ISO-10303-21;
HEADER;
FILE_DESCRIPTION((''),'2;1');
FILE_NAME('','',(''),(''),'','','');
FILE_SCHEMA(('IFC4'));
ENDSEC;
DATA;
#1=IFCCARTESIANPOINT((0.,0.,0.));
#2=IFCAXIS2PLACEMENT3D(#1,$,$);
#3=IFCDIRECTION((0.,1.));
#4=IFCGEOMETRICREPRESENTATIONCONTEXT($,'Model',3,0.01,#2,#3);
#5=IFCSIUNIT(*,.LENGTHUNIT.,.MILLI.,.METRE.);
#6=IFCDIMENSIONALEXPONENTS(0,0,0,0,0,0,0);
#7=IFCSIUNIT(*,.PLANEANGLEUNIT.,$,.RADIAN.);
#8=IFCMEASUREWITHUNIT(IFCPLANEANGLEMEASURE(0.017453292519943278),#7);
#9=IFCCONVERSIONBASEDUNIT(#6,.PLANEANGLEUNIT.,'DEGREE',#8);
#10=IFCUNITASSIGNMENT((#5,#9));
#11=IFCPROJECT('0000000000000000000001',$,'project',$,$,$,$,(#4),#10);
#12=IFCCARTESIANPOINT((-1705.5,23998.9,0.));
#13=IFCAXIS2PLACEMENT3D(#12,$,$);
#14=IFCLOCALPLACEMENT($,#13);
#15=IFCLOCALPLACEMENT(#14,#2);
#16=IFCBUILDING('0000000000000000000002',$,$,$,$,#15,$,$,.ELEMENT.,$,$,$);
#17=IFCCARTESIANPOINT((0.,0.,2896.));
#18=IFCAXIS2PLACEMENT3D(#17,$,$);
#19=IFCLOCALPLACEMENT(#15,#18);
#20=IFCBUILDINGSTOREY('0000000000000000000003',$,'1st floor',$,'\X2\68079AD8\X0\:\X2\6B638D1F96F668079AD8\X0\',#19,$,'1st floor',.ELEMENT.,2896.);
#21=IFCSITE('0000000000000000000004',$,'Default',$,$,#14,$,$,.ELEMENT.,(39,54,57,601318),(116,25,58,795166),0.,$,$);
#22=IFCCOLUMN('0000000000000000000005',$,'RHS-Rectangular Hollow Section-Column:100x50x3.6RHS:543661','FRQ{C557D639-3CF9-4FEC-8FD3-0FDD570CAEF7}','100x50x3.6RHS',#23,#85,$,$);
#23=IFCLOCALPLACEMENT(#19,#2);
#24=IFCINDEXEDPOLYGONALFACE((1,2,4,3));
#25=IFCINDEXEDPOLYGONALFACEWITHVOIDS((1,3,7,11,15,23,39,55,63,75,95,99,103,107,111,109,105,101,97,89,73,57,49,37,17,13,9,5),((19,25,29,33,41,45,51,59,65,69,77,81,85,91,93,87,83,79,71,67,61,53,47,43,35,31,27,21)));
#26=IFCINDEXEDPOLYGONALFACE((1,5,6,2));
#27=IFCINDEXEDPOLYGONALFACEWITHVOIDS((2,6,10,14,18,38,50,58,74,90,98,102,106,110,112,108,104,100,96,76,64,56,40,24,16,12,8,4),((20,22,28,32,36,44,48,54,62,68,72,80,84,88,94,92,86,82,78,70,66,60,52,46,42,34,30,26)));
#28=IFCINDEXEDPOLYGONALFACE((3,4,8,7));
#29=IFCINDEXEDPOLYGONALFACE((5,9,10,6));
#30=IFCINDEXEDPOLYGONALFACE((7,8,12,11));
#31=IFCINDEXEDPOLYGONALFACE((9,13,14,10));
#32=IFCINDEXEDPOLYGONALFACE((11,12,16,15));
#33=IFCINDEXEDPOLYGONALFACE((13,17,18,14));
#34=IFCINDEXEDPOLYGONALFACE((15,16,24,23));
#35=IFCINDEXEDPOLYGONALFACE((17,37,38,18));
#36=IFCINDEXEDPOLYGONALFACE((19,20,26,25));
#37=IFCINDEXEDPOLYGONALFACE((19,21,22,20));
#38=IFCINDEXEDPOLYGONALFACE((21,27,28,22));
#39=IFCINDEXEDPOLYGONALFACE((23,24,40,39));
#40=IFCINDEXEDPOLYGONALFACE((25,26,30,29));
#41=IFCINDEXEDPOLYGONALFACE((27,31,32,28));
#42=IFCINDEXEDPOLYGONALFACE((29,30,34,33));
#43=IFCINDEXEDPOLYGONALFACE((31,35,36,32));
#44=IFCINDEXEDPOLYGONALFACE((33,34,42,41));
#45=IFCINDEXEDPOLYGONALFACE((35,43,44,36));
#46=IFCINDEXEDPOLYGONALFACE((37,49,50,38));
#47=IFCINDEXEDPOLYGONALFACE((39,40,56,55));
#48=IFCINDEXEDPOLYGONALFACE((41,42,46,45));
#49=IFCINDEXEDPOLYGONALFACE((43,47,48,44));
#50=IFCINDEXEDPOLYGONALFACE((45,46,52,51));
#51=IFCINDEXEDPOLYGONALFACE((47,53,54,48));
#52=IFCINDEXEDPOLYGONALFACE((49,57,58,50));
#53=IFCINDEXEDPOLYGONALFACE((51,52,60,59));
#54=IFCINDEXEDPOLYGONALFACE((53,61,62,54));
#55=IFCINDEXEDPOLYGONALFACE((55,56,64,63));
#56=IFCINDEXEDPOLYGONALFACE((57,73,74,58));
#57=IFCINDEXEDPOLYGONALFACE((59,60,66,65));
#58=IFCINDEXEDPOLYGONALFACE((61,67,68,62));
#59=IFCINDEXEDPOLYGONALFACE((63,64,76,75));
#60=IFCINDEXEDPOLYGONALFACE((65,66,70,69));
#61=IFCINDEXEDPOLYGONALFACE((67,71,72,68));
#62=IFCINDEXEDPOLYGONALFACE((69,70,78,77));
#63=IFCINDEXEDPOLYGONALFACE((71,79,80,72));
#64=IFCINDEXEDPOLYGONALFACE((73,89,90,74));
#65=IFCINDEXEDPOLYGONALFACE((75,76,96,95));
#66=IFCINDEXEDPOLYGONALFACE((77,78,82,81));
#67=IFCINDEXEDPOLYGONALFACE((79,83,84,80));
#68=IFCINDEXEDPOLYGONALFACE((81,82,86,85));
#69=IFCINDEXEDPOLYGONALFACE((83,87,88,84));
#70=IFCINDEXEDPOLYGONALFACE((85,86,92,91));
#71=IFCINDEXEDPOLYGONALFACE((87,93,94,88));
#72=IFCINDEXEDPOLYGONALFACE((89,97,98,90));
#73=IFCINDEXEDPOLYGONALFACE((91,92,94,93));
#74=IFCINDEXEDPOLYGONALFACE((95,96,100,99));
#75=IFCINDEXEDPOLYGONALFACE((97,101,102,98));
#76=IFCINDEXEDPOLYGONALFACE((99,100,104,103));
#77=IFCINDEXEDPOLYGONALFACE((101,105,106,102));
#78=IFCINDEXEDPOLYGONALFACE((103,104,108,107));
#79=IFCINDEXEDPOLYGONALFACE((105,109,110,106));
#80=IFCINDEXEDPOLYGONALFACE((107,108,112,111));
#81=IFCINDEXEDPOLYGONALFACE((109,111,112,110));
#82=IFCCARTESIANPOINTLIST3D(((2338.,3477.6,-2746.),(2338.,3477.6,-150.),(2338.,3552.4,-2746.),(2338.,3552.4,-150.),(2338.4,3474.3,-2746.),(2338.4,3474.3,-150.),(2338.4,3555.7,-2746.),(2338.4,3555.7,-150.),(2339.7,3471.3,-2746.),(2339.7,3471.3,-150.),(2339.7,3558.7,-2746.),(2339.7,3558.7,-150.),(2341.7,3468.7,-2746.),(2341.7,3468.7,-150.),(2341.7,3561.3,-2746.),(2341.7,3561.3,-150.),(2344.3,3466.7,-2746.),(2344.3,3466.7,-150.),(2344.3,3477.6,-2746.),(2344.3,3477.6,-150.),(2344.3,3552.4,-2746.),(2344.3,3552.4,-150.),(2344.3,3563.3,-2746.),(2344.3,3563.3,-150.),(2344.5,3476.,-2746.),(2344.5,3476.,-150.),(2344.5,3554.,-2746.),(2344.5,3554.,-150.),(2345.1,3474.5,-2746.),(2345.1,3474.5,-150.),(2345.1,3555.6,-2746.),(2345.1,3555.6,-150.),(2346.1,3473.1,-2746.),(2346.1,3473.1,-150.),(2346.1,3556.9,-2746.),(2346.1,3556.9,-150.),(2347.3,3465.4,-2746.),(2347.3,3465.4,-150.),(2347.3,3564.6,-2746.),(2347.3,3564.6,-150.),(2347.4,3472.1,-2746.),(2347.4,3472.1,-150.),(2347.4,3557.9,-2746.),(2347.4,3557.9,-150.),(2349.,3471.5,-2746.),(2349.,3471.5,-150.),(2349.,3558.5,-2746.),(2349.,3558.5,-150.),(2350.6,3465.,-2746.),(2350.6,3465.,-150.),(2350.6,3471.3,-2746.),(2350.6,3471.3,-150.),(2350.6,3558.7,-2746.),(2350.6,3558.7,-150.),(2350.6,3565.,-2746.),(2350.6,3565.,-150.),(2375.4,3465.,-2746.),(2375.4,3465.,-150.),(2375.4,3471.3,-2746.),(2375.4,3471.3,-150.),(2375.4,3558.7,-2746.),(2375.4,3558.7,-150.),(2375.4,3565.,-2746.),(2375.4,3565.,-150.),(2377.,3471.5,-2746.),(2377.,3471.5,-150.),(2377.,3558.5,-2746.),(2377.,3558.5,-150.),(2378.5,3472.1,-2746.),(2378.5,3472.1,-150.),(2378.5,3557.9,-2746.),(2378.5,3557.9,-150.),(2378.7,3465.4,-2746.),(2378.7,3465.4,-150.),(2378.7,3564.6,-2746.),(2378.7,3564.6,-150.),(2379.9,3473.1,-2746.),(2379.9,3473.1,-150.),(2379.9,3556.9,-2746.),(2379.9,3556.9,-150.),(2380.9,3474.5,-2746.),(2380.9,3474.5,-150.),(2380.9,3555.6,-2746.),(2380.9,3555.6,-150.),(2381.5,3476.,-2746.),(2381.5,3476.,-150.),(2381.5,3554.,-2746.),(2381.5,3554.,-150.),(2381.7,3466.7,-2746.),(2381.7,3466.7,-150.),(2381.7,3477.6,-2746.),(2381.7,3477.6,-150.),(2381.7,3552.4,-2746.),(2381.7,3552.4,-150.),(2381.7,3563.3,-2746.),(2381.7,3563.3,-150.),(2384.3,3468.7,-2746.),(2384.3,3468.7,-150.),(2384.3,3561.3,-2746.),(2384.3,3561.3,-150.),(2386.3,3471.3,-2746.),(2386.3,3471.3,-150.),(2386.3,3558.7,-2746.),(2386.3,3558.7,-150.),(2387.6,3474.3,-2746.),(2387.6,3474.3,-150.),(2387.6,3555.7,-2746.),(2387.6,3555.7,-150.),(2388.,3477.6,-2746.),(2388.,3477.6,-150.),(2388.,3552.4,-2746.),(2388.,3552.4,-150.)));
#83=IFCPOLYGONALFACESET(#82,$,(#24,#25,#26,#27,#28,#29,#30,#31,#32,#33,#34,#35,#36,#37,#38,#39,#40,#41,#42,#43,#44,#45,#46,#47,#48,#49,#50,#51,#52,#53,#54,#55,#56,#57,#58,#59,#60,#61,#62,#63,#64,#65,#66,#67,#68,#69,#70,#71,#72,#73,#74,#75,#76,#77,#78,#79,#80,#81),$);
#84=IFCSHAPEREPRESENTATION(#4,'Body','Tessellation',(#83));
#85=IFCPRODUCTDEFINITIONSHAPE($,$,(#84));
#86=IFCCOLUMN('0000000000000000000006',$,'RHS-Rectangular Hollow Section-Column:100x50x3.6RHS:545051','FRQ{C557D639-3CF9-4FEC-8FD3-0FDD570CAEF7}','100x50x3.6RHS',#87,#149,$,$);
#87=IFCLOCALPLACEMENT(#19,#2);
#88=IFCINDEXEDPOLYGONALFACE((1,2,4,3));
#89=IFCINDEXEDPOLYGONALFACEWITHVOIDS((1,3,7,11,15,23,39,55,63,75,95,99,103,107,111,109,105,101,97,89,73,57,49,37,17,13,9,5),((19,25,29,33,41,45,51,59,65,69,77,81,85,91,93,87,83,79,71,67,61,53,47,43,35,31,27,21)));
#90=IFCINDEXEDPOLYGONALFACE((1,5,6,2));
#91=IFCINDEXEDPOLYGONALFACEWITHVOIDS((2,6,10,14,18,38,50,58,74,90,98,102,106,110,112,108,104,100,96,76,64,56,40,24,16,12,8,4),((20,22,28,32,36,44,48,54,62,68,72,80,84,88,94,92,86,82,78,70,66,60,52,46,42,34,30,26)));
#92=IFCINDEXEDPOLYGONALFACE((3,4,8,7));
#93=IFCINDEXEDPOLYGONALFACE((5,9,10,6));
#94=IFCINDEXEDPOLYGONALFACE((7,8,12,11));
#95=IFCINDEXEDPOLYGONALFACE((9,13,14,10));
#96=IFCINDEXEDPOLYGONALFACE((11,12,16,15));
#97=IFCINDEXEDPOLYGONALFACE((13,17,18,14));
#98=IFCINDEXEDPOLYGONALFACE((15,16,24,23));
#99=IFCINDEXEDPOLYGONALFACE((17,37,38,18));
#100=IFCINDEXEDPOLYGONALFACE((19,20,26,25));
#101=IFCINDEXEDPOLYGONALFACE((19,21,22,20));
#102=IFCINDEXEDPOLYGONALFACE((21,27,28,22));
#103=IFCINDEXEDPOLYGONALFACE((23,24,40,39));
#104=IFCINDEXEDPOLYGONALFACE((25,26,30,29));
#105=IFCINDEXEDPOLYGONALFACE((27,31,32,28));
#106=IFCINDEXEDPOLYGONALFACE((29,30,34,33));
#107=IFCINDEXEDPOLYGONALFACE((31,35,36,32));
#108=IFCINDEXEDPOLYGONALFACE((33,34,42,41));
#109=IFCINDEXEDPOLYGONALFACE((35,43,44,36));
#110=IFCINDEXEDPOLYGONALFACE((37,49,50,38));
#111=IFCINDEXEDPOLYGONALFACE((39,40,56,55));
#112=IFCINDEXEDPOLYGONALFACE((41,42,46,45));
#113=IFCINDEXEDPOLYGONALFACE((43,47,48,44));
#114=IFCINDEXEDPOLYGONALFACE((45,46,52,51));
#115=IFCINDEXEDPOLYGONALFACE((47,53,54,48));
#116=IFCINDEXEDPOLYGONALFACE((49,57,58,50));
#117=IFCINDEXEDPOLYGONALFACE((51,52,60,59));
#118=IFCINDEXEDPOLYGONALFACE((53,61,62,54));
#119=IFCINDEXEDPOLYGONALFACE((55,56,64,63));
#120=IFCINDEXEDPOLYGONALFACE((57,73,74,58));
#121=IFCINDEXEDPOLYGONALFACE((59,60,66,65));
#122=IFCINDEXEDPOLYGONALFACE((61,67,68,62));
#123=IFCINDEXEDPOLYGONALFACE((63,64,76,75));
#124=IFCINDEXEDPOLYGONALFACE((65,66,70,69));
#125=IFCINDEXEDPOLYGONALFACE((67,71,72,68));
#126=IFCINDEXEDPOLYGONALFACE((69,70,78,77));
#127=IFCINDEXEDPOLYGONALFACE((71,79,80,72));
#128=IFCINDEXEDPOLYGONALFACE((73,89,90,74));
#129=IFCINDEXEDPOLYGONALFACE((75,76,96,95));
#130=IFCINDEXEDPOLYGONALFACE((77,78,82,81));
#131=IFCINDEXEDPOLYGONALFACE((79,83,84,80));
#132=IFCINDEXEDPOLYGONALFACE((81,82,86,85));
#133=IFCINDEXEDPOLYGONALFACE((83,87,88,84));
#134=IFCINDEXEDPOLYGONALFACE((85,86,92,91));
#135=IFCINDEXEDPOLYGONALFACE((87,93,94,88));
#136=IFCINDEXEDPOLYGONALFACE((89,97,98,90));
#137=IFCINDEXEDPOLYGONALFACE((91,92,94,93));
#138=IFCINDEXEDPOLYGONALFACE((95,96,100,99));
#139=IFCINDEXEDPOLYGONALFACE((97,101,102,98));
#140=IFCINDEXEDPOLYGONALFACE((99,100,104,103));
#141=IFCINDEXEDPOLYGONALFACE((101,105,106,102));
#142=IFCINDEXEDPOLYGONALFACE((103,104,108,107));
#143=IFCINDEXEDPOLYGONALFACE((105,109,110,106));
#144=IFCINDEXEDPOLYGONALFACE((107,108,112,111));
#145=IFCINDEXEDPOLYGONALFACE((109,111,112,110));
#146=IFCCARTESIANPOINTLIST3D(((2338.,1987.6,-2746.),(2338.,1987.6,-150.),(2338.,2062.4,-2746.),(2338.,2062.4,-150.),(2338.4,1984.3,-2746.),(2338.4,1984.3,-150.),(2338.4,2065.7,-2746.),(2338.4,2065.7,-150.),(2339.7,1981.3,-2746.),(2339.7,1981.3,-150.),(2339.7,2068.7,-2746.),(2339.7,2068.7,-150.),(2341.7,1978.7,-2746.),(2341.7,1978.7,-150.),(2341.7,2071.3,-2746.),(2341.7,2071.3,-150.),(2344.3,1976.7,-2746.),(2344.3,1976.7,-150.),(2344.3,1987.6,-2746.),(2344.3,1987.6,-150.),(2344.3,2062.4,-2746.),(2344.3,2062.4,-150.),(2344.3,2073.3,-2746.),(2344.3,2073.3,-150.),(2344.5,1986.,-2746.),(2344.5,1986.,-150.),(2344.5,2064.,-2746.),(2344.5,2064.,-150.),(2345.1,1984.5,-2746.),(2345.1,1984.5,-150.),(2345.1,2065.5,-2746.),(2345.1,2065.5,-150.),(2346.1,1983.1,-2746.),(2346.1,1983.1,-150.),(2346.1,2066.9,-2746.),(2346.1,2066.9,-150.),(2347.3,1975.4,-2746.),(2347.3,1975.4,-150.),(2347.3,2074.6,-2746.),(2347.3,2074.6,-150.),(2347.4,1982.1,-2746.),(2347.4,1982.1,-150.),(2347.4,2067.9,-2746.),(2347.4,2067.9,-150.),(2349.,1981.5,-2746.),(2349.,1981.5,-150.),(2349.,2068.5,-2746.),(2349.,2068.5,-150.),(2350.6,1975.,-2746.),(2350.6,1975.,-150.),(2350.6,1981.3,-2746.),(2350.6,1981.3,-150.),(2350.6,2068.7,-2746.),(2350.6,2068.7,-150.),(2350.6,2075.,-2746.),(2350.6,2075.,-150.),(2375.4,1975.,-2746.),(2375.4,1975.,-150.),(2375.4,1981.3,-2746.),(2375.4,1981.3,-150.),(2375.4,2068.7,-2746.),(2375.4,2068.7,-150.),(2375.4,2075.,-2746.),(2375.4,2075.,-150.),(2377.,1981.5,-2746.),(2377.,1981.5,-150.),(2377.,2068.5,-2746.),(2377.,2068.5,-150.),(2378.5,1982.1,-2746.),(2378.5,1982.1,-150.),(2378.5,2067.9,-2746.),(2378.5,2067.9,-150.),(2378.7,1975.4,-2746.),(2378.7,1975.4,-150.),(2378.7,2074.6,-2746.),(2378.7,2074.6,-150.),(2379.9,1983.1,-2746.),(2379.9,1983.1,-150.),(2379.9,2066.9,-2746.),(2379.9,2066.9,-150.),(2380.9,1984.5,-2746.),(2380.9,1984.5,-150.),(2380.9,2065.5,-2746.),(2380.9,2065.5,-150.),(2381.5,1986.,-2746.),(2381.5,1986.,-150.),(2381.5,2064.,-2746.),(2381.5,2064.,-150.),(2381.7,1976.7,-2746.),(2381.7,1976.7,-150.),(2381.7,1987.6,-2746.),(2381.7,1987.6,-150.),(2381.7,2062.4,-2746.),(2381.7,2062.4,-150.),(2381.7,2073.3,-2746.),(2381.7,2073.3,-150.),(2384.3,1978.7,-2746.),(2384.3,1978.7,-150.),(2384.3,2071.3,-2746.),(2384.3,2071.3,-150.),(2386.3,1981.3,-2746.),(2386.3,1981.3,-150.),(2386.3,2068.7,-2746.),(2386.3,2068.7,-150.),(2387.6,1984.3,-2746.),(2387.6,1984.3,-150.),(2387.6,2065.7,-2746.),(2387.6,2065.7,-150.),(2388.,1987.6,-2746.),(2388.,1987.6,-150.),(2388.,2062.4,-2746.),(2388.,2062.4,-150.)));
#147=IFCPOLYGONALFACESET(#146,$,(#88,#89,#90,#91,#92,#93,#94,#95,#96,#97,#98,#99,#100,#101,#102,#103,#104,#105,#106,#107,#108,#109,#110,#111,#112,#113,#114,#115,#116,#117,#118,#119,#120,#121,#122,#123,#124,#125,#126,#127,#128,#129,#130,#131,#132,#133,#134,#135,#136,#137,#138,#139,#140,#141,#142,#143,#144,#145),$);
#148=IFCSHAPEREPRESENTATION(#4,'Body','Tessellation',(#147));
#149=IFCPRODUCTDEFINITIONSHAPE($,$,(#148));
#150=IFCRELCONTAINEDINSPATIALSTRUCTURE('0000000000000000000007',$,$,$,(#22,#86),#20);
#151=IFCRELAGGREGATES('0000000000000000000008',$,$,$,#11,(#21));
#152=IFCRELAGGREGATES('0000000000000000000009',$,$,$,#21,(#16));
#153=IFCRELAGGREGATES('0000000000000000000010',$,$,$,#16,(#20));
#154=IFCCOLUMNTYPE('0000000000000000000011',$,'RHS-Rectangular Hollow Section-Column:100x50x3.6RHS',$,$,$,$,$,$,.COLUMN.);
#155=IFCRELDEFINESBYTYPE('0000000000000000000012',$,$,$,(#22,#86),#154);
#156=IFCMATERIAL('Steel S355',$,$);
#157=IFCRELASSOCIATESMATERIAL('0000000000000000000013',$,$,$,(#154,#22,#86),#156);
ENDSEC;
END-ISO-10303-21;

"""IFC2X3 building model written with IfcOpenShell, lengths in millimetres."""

from ifc_helpers import new_model, entity, si_unit, converted_unit, direction, frame, origin, origin_2d, place, context, project, spatial, hollow_rectangle, extrude, clip, halfspace, material, type_object, element, save


model = new_model("IFC2X3")

# Units and contexts
model_context = context("Model", 3, precision=0.01, world=origin(), true_north=direction((0.0, 1.0)))
ifc_project = project(units=[si_unit("LENGTHUNIT", "METRE", prefix="MILLI"), converted_unit("PLANEANGLEUNIT", "DEGREE", entity("IfcPlaneAngleMeasure", 0.017453292519943278), si_unit("PLANEANGLEUNIT", "RADIAN"), dimensions=[0, 0, 0, 0, 0, 0, 0])], contexts=[model_context])

# Site, building, storey
site_placement = place(None, frame((-1705.5, 23998.9, 0.0)))
site = spatial("IfcSite", under=ifc_project, at=site_placement, Name="Default", CompositionType="ELEMENT", RefLatitude=(39, 54, 57, 601318), RefLongitude=(116, 25, 58, 795166), RefElevation=0.0)
building_placement = place(site_placement, origin())
building = spatial("IfcBuilding", under=site, at=building_placement, CompositionType="ELEMENT")
storey_placement = place(building_placement, frame((0.0, 0.0, 2896.0)))
storey = spatial("IfcBuildingStorey", under=building, at=storey_placement, Name="1st floor", ObjectType="标高:正负零标高", LongName="1st floor", CompositionType="ELEMENT", Elevation=2896.0)

# Shared definitions
ifc_material_1 = material(Name="Steel S355")

# Columns
column_type_1 = type_object("IfcColumnType", Name="RHS-Rectangular Hollow Section-Column:100x50x3.6RHS", PredefinedType="COLUMN", material=ifc_material_1)
column_1_placement = place(storey_placement, frame((2363.0, 3515.0, -150.0), z_axis=(0.0, 0.0, 1.0), x_axis=(-1.0, 0.0, 0.0)))
element("IfcColumn", 1, at=column_1_placement, inside=storey, type_object=column_type_1, material=ifc_material_1, Name="RHS-Rectangular Hollow Section-Column:100x50x3.6RHS:543661", Description="FRQ{C557D639-3CF9-4FEC-8FD3-0FDD570CAEF7}", ObjectType="100x50x3.6RHS", context=model_context, shape_type="Clipping", body=[
    clip(extrude(hollow_rectangle(XDim=50.0, YDim=100.0, WallThickness=6.3, InnerFilletRadius=6.3, OuterFilletRadius=12.6, at=origin_2d()), origin(), (0.0, 0.0, -1.0), 2651.9), halfspace(frame((2363.0, 3515.0, -2596.0), z_axis=(0.0, 0.0, 1.0), x_axis=(-1.0, 0.0, 0.0)), True)),
])
column_2_placement = place(storey_placement, frame((2363.0, 2025.0, -150.0), z_axis=(0.0, 0.0, 1.0), x_axis=(-1.0, 0.0, 0.0)))
element("IfcColumn", 2, at=column_2_placement, inside=storey, type_object=column_type_1, material=ifc_material_1, Name="RHS-Rectangular Hollow Section-Column:100x50x3.6RHS:545051", Description="FRQ{C557D639-3CF9-4FEC-8FD3-0FDD570CAEF7}", ObjectType="100x50x3.6RHS", context=model_context, shape_type="Clipping", body=[
    clip(extrude(hollow_rectangle(XDim=50.0, YDim=100.0, WallThickness=6.3, InnerFilletRadius=6.3, OuterFilletRadius=12.6, at=origin_2d()), origin(), (0.0, 0.0, -1.0), 2651.9), halfspace(frame((2363.0, 2025.0, -2596.0), z_axis=(0.0, 0.0, 1.0), x_axis=(-1.0, 0.0, 0.0)), True)),
])

save(model, "model.ifc")
